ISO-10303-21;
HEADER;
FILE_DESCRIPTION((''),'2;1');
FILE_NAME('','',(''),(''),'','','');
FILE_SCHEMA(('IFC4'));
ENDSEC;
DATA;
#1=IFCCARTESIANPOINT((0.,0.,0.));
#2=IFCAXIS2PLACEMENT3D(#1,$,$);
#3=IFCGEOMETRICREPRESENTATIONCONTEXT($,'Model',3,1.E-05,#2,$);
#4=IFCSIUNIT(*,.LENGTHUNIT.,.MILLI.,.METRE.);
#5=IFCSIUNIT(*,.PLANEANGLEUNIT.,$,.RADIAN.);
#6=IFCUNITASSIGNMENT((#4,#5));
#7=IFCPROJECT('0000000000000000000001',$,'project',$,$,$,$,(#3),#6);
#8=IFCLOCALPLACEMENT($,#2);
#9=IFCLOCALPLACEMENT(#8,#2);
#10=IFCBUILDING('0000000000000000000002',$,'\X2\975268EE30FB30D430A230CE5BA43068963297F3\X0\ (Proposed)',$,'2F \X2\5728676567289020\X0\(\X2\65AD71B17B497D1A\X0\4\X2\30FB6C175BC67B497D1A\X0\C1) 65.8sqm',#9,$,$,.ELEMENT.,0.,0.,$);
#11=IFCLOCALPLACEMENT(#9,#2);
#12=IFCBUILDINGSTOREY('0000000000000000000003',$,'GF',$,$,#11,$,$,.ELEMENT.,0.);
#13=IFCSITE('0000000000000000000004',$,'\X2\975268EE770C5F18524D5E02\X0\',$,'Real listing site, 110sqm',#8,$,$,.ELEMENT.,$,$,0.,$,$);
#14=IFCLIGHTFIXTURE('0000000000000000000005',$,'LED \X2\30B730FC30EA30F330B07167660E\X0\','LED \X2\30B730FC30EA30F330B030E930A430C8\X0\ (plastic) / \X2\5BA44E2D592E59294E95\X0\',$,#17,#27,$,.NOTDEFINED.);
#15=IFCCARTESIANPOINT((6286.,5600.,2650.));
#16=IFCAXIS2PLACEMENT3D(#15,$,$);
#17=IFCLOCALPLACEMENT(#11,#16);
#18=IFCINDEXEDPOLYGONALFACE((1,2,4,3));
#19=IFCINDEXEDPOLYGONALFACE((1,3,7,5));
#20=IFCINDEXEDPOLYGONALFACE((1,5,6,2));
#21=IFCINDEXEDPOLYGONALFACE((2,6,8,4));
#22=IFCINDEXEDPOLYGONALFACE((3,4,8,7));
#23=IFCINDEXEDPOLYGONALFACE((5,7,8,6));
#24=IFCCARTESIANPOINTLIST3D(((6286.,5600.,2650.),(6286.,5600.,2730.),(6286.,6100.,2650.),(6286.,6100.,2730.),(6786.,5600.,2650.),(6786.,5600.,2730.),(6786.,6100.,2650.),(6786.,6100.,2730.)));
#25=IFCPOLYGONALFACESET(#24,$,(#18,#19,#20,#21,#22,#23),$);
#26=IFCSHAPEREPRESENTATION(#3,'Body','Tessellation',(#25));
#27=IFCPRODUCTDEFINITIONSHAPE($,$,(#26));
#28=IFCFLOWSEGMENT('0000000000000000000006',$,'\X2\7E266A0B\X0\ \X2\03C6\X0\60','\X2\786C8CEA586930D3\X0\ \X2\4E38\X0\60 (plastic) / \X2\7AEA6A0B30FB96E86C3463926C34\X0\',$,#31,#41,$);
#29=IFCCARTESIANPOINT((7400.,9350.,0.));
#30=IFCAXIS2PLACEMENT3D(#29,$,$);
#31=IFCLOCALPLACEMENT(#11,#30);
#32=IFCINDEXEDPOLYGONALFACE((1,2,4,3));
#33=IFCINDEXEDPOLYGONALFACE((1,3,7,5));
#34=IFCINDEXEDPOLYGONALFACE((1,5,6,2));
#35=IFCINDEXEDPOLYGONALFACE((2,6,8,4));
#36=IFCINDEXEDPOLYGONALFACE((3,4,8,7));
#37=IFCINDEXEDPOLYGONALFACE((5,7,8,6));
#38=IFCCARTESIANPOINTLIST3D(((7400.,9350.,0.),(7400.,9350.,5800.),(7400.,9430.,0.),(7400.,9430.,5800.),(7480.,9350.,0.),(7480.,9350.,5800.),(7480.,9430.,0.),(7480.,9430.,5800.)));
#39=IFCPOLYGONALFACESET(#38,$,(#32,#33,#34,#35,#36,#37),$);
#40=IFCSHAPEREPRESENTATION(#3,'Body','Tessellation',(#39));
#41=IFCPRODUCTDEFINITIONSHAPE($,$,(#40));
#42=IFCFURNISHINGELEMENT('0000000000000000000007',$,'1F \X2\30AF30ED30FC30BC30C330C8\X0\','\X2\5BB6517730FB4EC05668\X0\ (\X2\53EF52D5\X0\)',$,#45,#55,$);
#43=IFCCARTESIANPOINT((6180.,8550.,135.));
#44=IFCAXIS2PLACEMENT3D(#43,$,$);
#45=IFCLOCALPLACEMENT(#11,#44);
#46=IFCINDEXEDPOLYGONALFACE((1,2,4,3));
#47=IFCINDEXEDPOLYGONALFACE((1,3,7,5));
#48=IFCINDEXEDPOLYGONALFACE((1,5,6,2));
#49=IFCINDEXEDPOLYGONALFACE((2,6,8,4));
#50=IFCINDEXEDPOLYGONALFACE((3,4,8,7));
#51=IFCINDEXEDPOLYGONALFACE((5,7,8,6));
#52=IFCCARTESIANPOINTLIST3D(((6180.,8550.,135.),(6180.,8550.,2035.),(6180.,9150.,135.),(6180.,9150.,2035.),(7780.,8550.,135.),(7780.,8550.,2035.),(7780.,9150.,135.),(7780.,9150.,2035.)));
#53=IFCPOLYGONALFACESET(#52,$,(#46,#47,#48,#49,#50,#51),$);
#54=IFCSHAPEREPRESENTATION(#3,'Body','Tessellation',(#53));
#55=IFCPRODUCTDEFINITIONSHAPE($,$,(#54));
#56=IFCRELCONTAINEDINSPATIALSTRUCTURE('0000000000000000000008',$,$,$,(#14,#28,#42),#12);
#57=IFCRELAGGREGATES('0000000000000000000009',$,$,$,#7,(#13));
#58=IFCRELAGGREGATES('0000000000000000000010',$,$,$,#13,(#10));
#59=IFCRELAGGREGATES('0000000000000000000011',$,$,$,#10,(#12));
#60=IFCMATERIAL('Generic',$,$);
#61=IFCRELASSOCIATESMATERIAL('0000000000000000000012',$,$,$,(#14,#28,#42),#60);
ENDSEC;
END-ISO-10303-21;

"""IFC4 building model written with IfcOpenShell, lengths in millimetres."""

from ifc_helpers import new_model, si_unit, frame, frame_2d, origin, place, context, project, spatial, rectangle, extrude, material, element, save


model = new_model("IFC4")

# Units and contexts
model_context = context("Model", 3, precision=1e-05, world=origin())
ifc_project = project(units=[si_unit("LENGTHUNIT", "METRE", prefix="MILLI"), si_unit("PLANEANGLEUNIT", "RADIAN")], contexts=[model_context])

# Site, building, storey
site_placement = place(None, origin())
site = spatial("IfcSite", under=ifc_project, at=site_placement, Name="青森県弘前市", ObjectType="Real listing site, 110sqm", CompositionType="ELEMENT", RefElevation=0.0)
building_placement = place(site_placement, origin())
building = spatial("IfcBuilding", under=site, at=building_placement, Name="青森・ピアノ室と防音 (Proposed)", ObjectType="2F 在来木造(断熱等級4・気密等級C1) 65.8sqm", CompositionType="ELEMENT", ElevationOfRefHeight=0.0, ElevationOfTerrain=0.0)
storey_placement = place(building_placement, origin())
storey = spatial("IfcBuildingStorey", under=building, at=storey_placement, Name="GF", CompositionType="ELEMENT", Elevation=0.0)

# Shared definitions
ifc_material_1 = material(Name="Generic")

# Light fixture
light_fixture_placement = place(storey_placement, frame((6286.0, 5600.0, 2650.0)))
element("IfcLightFixture", 1, at=light_fixture_placement, inside=storey, material=ifc_material_1, Name="LED シーリング照明", Description="LED シーリングライト (plastic) / 室中央天井", PredefinedType="NOTDEFINED", context=model_context, shape_type="SweptSolid", body=[
    extrude(rectangle(XDim=500.0, YDim=500.0, at=frame_2d((250.0, 250.0))), frame((6286.0, 5600.0, 2650.0)), (0.0, 0.0, 1.0), 80.0),
])

# Flow segment
flow_segment_placement = place(storey_placement, frame((7400.0, 9350.0, 0.0)))
element("IfcFlowSegment", 2, at=flow_segment_placement, inside=storey, material=ifc_material_1, Name="縦樋 φ60", Description="硬質塩ビ 丸60 (plastic) / 竪樋・雨水排水", context=model_context, shape_type="SweptSolid", body=[
    extrude(rectangle(XDim=80.0, YDim=80.0, at=frame_2d((40.0, 40.0))), frame((7400.0, 9350.0, 0.0)), (0.0, 0.0, 1.0), 5800.0),
])

# Furnishing element
furnishing_placement = place(storey_placement, frame((6180.0, 8550.0, 135.0)))
element("IfcFurnishingElement", 3, at=furnishing_placement, inside=storey, material=ifc_material_1, Name="1F クローゼット", Description="家具・什器 (可動)", context=model_context, shape_type="SweptSolid", body=[
    extrude(rectangle(XDim=1600.0, YDim=600.0, at=frame_2d((800.0, 300.0))), frame((6180.0, 8550.0, 135.0)), (0.0, 0.0, 1.0), 1900.0),
])

save(model, "model.ifc")
